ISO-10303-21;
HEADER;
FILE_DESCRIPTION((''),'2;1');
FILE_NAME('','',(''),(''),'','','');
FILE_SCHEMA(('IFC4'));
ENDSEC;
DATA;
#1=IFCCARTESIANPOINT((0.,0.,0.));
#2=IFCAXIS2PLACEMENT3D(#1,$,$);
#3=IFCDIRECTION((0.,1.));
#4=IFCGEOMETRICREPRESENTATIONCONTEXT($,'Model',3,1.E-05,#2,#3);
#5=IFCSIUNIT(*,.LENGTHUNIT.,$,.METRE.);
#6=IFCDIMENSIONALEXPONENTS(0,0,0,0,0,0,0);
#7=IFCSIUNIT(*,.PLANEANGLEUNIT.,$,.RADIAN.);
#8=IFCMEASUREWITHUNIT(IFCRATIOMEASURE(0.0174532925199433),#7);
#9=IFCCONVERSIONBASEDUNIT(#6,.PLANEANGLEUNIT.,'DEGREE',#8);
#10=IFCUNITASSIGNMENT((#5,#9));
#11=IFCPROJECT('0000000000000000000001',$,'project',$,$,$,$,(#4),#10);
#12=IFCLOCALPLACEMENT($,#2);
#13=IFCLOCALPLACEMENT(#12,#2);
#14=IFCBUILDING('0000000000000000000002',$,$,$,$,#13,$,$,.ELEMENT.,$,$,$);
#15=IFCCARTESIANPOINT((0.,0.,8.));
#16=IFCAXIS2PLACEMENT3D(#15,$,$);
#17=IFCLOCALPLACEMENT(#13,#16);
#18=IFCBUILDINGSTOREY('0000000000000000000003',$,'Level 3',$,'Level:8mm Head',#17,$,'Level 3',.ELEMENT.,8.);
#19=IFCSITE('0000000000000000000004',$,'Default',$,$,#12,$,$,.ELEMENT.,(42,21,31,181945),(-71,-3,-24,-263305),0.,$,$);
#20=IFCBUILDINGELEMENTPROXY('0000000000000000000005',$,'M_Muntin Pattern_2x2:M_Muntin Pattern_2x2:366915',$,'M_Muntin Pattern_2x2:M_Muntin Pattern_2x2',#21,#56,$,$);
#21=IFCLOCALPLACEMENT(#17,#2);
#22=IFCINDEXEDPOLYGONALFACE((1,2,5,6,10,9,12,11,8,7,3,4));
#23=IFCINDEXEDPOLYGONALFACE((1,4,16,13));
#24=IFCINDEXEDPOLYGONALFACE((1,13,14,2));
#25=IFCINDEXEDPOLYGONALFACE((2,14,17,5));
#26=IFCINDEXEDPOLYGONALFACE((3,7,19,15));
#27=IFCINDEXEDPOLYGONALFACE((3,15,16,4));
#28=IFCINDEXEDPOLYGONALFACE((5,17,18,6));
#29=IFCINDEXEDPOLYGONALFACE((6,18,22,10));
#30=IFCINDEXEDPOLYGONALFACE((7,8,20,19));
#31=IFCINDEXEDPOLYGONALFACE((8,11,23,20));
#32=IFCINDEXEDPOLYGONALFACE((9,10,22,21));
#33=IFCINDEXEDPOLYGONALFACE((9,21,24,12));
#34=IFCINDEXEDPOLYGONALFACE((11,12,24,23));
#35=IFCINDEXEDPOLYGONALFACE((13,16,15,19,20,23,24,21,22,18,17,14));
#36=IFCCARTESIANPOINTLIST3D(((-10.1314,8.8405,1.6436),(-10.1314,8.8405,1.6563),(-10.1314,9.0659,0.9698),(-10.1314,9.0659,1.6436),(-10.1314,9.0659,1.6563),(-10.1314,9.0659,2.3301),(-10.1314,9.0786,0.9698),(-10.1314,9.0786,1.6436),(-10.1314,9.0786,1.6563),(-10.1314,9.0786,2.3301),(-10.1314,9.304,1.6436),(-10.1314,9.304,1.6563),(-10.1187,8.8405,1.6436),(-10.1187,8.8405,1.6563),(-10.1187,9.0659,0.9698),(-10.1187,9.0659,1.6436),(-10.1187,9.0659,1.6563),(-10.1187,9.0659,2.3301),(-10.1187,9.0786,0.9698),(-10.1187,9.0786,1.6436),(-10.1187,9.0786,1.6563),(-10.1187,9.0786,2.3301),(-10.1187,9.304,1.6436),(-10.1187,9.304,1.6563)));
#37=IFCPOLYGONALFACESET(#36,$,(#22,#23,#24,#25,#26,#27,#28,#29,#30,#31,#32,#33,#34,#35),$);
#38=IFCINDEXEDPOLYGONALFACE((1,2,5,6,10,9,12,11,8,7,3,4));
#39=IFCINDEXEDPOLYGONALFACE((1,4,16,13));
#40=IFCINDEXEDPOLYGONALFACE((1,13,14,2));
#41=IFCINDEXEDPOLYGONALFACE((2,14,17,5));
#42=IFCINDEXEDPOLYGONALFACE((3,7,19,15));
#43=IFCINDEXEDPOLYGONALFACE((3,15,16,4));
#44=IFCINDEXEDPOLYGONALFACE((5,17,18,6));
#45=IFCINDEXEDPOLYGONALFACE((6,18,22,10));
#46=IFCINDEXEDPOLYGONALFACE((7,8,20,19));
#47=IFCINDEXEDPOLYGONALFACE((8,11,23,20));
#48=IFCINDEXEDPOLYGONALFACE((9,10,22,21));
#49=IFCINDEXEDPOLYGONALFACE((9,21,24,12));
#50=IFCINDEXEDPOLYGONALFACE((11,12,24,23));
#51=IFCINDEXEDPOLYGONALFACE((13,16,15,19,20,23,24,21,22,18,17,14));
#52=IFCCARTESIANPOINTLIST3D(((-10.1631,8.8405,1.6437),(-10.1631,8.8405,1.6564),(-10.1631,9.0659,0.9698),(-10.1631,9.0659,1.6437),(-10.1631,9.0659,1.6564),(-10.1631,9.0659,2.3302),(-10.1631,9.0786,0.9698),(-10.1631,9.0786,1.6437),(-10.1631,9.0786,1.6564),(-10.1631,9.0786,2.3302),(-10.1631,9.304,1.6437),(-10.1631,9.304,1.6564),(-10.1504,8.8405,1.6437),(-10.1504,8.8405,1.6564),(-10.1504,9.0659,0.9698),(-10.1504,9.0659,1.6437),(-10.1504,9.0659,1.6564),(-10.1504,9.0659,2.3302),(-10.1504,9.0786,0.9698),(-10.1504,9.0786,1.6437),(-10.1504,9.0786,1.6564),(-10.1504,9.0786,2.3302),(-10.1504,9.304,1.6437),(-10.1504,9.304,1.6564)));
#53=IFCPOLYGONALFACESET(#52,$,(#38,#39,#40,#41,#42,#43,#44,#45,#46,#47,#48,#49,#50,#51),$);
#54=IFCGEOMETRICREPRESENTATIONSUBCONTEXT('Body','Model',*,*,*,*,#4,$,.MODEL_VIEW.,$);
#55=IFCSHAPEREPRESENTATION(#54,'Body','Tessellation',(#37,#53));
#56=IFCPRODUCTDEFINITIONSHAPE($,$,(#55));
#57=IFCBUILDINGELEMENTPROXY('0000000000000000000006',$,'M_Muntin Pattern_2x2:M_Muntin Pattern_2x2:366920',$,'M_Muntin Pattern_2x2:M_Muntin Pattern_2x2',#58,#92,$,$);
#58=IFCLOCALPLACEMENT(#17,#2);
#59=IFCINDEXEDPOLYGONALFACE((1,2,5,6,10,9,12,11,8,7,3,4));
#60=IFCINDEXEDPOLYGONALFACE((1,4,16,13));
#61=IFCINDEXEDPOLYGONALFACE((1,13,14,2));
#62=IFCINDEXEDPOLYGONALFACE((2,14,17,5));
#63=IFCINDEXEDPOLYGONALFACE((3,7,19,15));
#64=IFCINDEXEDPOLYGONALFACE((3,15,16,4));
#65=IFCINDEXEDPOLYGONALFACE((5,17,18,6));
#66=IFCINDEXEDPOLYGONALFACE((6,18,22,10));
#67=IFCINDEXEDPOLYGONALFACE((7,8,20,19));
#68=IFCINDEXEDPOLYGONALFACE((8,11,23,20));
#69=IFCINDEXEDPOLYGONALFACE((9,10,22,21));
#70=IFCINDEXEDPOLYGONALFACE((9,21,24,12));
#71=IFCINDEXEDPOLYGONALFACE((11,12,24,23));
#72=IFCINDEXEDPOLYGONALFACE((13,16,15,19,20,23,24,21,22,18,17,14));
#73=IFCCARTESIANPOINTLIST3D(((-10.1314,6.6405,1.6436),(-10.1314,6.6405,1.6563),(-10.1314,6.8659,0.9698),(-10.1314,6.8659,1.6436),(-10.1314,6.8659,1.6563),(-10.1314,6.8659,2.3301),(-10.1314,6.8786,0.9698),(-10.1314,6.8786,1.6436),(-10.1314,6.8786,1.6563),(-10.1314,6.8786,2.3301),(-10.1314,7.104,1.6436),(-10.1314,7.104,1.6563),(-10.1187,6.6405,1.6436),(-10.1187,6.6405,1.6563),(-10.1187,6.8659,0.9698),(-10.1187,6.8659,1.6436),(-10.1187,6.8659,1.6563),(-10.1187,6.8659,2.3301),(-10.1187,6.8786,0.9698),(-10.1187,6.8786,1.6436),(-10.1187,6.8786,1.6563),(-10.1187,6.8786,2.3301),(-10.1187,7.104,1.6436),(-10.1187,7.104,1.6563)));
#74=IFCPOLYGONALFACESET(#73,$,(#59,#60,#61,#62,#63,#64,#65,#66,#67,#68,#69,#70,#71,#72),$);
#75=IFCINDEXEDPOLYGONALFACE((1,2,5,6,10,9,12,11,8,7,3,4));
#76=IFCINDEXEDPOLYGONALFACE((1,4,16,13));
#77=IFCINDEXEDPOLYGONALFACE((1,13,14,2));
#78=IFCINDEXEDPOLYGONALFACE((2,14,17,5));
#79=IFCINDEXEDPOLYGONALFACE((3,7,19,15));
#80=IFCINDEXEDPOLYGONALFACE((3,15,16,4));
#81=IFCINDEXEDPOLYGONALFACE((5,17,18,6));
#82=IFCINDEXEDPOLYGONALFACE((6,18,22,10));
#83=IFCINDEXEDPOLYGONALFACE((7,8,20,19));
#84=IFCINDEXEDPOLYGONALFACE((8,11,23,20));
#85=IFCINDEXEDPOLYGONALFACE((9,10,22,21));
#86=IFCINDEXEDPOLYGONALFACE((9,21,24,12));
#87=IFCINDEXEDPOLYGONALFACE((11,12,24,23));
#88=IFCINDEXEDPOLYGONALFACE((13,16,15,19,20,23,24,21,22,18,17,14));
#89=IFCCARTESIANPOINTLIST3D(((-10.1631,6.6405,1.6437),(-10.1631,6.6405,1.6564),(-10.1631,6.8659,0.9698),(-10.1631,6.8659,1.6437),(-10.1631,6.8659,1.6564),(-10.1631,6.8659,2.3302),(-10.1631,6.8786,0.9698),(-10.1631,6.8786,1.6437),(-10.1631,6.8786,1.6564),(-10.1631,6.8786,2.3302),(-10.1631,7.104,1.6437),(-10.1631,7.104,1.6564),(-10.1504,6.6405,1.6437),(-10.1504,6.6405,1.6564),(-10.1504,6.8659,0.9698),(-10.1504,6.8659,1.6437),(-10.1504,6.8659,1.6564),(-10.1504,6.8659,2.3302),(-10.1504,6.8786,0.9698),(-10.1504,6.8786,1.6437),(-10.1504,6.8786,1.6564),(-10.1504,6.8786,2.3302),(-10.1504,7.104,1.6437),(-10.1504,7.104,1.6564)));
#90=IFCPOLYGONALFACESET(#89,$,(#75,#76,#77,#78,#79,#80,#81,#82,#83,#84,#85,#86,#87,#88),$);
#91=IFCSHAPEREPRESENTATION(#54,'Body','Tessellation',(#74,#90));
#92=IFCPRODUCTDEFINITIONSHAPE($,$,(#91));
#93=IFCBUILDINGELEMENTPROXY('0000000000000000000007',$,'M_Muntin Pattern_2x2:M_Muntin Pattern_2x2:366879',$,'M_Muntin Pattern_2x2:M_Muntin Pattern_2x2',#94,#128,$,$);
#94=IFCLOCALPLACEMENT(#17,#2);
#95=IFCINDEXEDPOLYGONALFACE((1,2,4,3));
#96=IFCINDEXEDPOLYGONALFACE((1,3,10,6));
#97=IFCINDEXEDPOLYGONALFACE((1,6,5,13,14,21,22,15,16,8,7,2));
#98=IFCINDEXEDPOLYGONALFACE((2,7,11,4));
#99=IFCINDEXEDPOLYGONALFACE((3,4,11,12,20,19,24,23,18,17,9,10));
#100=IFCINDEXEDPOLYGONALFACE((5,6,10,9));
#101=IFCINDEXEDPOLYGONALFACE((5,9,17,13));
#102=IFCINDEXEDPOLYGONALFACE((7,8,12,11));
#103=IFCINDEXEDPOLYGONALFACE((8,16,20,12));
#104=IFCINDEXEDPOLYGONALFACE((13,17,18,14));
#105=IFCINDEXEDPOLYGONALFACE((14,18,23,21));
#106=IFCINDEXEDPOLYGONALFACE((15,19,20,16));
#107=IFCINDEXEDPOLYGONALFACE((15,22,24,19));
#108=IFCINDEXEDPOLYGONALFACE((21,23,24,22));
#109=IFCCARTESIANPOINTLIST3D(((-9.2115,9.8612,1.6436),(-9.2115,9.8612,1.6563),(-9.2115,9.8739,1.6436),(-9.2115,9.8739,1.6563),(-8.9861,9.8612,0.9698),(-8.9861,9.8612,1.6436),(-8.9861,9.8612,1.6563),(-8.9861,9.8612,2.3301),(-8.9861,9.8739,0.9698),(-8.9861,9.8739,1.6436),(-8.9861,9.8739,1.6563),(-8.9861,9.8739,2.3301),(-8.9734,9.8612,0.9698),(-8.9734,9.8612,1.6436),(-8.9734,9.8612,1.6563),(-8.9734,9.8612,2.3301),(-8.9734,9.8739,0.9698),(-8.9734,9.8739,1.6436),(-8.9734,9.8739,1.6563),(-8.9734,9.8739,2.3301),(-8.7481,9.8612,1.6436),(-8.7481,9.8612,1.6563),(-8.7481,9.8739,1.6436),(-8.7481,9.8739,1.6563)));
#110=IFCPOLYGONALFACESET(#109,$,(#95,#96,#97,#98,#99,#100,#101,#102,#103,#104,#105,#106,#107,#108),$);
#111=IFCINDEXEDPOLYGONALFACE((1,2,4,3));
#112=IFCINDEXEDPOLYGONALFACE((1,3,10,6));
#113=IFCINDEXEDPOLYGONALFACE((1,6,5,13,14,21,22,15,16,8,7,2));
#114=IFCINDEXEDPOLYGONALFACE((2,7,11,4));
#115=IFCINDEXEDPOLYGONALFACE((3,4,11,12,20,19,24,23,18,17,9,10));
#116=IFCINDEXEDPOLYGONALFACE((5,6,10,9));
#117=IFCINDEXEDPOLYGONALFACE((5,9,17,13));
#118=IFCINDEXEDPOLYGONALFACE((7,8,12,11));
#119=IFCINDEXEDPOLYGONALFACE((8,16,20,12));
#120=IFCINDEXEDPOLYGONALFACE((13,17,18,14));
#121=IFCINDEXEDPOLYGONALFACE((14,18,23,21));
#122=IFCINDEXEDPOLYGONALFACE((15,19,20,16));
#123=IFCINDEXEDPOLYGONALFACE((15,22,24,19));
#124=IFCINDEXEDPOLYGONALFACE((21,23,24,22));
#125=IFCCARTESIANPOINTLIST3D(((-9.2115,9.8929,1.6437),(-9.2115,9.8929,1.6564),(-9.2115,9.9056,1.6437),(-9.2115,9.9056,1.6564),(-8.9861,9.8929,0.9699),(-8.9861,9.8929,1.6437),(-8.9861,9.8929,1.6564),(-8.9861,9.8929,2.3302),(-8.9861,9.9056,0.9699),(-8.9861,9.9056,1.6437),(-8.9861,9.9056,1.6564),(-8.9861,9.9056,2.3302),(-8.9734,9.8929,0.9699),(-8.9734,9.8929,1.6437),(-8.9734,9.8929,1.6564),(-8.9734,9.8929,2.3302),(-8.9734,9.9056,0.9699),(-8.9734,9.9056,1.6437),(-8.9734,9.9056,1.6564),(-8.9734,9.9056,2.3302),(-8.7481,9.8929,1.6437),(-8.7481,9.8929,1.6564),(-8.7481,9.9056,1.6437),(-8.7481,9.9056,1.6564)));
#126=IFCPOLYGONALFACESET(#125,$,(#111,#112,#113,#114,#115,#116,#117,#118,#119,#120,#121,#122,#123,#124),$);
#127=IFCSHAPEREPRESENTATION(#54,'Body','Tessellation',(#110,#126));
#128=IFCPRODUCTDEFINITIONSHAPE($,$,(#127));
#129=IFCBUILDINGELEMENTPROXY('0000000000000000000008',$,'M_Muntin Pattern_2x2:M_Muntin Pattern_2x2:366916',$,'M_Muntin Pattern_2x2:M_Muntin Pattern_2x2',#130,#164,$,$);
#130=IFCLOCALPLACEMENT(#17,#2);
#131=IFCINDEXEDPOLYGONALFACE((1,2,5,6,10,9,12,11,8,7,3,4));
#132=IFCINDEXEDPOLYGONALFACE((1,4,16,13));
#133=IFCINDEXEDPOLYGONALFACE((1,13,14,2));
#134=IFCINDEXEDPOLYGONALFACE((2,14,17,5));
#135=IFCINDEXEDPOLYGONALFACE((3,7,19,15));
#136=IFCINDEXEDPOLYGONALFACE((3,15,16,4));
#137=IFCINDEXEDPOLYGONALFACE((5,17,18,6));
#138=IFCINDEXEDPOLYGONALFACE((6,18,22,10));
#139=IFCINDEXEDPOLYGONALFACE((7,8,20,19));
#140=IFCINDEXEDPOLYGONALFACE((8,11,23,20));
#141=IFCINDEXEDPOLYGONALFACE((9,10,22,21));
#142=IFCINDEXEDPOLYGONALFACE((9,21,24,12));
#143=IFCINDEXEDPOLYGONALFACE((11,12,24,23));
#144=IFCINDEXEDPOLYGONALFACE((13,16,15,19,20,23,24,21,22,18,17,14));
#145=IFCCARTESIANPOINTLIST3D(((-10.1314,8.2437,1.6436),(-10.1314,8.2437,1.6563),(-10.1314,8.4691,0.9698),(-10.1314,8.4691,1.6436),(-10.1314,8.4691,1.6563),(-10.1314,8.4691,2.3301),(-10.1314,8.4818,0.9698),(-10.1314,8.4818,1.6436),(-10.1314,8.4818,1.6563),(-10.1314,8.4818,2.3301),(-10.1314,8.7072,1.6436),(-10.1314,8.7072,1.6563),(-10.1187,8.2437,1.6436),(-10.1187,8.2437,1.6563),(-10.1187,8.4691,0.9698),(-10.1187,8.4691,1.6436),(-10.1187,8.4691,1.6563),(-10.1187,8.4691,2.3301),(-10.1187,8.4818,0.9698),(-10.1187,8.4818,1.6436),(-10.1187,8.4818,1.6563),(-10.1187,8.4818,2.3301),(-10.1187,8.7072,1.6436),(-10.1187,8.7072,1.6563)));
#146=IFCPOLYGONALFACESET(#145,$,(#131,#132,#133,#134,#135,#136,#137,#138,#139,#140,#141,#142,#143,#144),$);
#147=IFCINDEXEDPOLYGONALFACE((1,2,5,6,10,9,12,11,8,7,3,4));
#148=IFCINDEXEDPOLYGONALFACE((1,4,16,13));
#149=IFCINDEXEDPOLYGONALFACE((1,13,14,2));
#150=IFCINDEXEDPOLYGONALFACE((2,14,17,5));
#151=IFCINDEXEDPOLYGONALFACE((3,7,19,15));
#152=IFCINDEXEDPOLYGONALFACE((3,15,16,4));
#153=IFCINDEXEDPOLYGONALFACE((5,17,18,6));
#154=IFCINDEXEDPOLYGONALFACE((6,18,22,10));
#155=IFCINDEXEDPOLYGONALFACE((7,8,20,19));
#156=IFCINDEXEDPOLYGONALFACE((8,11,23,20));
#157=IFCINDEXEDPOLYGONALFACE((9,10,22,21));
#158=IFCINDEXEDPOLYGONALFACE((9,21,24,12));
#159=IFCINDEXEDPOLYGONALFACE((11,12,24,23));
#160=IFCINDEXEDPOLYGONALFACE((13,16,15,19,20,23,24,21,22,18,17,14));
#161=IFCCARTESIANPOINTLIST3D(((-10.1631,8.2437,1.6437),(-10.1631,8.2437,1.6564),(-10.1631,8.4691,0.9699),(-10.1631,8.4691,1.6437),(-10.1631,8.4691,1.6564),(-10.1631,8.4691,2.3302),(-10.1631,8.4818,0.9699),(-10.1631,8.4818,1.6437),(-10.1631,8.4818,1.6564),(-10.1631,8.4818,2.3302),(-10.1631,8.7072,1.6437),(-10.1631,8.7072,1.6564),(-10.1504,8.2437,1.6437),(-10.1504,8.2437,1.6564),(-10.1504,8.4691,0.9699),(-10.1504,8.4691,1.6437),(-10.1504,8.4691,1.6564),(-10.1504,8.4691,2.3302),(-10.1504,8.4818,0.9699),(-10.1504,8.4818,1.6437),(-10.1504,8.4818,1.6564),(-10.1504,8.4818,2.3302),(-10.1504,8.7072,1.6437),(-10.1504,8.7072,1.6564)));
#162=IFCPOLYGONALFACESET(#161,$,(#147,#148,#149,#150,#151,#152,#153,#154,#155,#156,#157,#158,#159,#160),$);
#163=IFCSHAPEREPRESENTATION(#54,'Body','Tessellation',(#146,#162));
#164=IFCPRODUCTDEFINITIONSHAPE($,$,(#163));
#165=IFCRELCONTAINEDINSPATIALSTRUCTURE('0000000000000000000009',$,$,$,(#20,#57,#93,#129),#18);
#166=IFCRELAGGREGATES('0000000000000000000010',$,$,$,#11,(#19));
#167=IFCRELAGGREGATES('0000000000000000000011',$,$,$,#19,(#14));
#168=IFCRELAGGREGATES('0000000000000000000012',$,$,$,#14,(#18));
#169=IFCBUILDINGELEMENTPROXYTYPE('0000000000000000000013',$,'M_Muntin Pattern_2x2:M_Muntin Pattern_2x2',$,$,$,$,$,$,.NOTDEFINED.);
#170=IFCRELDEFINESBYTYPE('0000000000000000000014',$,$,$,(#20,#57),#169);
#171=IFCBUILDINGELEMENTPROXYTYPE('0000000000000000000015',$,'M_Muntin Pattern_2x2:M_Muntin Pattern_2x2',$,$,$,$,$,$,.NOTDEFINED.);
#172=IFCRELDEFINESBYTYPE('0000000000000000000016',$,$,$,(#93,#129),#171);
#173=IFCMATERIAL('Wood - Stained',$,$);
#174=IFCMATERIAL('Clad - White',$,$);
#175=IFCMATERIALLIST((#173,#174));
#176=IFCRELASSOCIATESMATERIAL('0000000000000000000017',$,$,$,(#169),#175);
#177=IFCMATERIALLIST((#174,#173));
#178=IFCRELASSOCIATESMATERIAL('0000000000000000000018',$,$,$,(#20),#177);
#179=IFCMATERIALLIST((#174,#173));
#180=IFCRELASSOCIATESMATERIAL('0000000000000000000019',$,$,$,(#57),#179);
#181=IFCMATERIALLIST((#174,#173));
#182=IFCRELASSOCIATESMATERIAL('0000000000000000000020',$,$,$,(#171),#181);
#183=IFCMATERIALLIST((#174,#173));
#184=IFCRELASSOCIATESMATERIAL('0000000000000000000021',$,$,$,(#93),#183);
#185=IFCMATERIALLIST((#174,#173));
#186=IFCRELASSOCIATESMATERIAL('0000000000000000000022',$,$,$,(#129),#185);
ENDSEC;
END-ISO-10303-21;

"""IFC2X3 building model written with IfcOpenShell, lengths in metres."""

from ifc_helpers import new_model, entity, si_unit, converted_unit, direction, frame, origin, place, context, subcontext, project, spatial, polyline, outline, extrude, source, transform, mapped, material, material_list, type_object, type_shapes, element, save


model = new_model("IFC2X3")

# Units and contexts
model_context = context("Model", 3, precision=1e-05, world=origin(), true_north=direction((0.0, 1.0)))
body_context = subcontext(model_context, "Body", "Model", "MODEL_VIEW")
ifc_project = project(units=[si_unit("LENGTHUNIT", "METRE"), converted_unit("PLANEANGLEUNIT", "DEGREE", entity("IfcRatioMeasure", 0.0174532925199433), si_unit("PLANEANGLEUNIT", "RADIAN"), dimensions=[0, 0, 0, 0, 0, 0, 0])], contexts=[model_context])

# Site, building, storey
site_placement = place(None, origin())
site = spatial("IfcSite", under=ifc_project, at=site_placement, Name="Default", CompositionType="ELEMENT", RefLatitude=(42, 21, 31, 181945), RefLongitude=(-71, -3, -24, -263305), RefElevation=0.0)
building_placement = place(site_placement, origin())
building = spatial("IfcBuilding", under=site, at=building_placement, CompositionType="ELEMENT")
storey_placement = place(building_placement, frame((0.0, 0.0, 8.0)))
storey = spatial("IfcBuildingStorey", under=building, at=storey_placement, Name="Level 3", ObjectType="Level:8mm Head", LongName="Level 3", CompositionType="ELEMENT", Elevation=8.0)

# Building element proxies
ifc_material_1 = material(Name="Clad - White")
ifc_material_2 = material(Name="Wood - Stained")
ifc_material_list_1 = material_list([ifc_material_2, ifc_material_1])
building_element_proxy_type_1 = type_object("IfcBuildingElementProxyType", Name="M_Muntin Pattern_2x2:M_Muntin Pattern_2x2", PredefinedType="NOTDEFINED", material=ifc_material_list_1)
shared_shape_1 = source(origin(), body_context, "Body", "SweptSolid", [
    extrude(outline(polyline([(0.0064, -0.0064), (0.6801, -0.0064), (0.6801, 0.0063), (0.0064, 0.0063), (0.0064, 0.2317), (-0.0063, 0.2317), (-0.0063, 0.0063), (-0.6802, 0.0063), (-0.6802, -0.0064), (-0.0063, -0.0064), (-0.0063, -0.2317), (0.0064, -0.2317), (0.0064, -0.0064)])), frame((0.0, 0.0095, 0.6801), z_axis=(0.0, 1.0, 0.0), x_axis=(0.0, 0.0, 1.0)), (0.0, 0.0, 1.0), 0.0127),
    extrude(outline(polyline([(0.0064, -0.0064), (0.6802, -0.0064), (0.6802, 0.0063), (0.0064, 0.0063), (0.0064, 0.2317), (-0.0063, 0.2317), (-0.0063, 0.0063), (-0.6802, 0.0063), (-0.6802, -0.0064), (-0.0063, -0.0064), (-0.0063, -0.2317), (0.0064, -0.2317), (0.0064, -0.0064)])), frame((0.0, -0.0222, 0.6802), z_axis=(0.0, 1.0, 0.0), x_axis=(0.0, 0.0, 1.0)), (0.0, 0.0, 1.0), 0.0127),
])
type_shapes(building_element_proxy_type_1, [shared_shape_1])
ifc_material_list_2 = material_list([ifc_material_1, ifc_material_2])
proxy_1_placement = place(storey_placement, frame((-10.1409, 9.0723, 0.9698), z_axis=(0.0, 0.0, 1.0), x_axis=(0.0, -1.0, 0.0)))
element("IfcBuildingElementProxy", 1, at=proxy_1_placement, inside=storey, type_object=building_element_proxy_type_1, material=ifc_material_list_2, Name="M_Muntin Pattern_2x2:M_Muntin Pattern_2x2:366915", ObjectType="M_Muntin Pattern_2x2:M_Muntin Pattern_2x2", context=body_context, shape_type="MappedRepresentation", body=[
    mapped(shared_shape_1, transform((0.0, 0.0, 0.0), scale=1.0)),
])
ifc_material_list_3 = material_list([ifc_material_1, ifc_material_2])
proxy_2_placement = place(storey_placement, frame((-10.1409, 6.8723, 0.9698), z_axis=(0.0, 0.0, 1.0), x_axis=(0.0, -1.0, 0.0)))
element("IfcBuildingElementProxy", 2, at=proxy_2_placement, inside=storey, type_object=building_element_proxy_type_1, material=ifc_material_list_3, Name="M_Muntin Pattern_2x2:M_Muntin Pattern_2x2:366920", ObjectType="M_Muntin Pattern_2x2:M_Muntin Pattern_2x2", context=body_context, shape_type="MappedRepresentation", body=[
    mapped(shared_shape_1, transform((0.0, 0.0, 0.0), scale=1.0)),
])
ifc_material_list_4 = material_list([ifc_material_1, ifc_material_2])
ifc_material_list_5 = material_list([ifc_material_1, ifc_material_2])
building_element_proxy_type_2 = type_object("IfcBuildingElementProxyType", Name="M_Muntin Pattern_2x2:M_Muntin Pattern_2x2", PredefinedType="NOTDEFINED", material=ifc_material_list_5)
shared_shape_2 = source(origin(), body_context, "Body", "SweptSolid", [
    extrude(outline(polyline([(0.0064, -0.0064), (0.6801, -0.0064), (0.6801, 0.0063), (0.0064, 0.0063), (0.0064, 0.2317), (-0.0063, 0.2317), (-0.0063, 0.0063), (-0.6802, 0.0063), (-0.6802, -0.0064), (-0.0063, -0.0064), (-0.0063, -0.2317), (0.0064, -0.2317), (0.0064, -0.0064)])), frame((0.0, -0.0222, 0.6801), z_axis=(0.0, 1.0, 0.0), x_axis=(0.0, 0.0, 1.0)), (0.0, 0.0, 1.0), 0.0127),
    extrude(outline(polyline([(0.0064, -0.0064), (0.6802, -0.0064), (0.6802, 0.0063), (0.0064, 0.0063), (0.0064, 0.2317), (-0.0063, 0.2317), (-0.0063, 0.0063), (-0.6802, 0.0063), (-0.6802, -0.0064), (-0.0063, -0.0064), (-0.0063, -0.2317), (0.0064, -0.2317), (0.0064, -0.0064)])), frame((0.0, 0.0095, 0.6802), z_axis=(0.0, 1.0, 0.0), x_axis=(0.0, 0.0, 1.0)), (0.0, 0.0, 1.0), 0.0127),
])
type_shapes(building_element_proxy_type_2, [shared_shape_2])
proxy_3_placement = place(storey_placement, frame((-8.9798, 9.8834, 0.9699)))
element("IfcBuildingElementProxy", 3, at=proxy_3_placement, inside=storey, type_object=building_element_proxy_type_2, material=ifc_material_list_4, Name="M_Muntin Pattern_2x2:M_Muntin Pattern_2x2:366879", ObjectType="M_Muntin Pattern_2x2:M_Muntin Pattern_2x2", context=body_context, shape_type="MappedRepresentation", body=[
    mapped(shared_shape_2, transform((0.0, 0.0, 0.0), scale=1.0)),
])
ifc_material_list_6 = material_list([ifc_material_1, ifc_material_2])
proxy_4_placement = place(storey_placement, frame((-10.1409, 8.4754, 0.9699), z_axis=(0.0, 0.0, 1.0), x_axis=(0.0, 1.0, 0.0)))
element("IfcBuildingElementProxy", 4, at=proxy_4_placement, inside=storey, type_object=building_element_proxy_type_2, material=ifc_material_list_6, Name="M_Muntin Pattern_2x2:M_Muntin Pattern_2x2:366916", ObjectType="M_Muntin Pattern_2x2:M_Muntin Pattern_2x2", context=body_context, shape_type="MappedRepresentation", body=[
    mapped(shared_shape_2, transform((0.0, 0.0, 0.0), scale=1.0)),
])

save(model, "model.ifc")
